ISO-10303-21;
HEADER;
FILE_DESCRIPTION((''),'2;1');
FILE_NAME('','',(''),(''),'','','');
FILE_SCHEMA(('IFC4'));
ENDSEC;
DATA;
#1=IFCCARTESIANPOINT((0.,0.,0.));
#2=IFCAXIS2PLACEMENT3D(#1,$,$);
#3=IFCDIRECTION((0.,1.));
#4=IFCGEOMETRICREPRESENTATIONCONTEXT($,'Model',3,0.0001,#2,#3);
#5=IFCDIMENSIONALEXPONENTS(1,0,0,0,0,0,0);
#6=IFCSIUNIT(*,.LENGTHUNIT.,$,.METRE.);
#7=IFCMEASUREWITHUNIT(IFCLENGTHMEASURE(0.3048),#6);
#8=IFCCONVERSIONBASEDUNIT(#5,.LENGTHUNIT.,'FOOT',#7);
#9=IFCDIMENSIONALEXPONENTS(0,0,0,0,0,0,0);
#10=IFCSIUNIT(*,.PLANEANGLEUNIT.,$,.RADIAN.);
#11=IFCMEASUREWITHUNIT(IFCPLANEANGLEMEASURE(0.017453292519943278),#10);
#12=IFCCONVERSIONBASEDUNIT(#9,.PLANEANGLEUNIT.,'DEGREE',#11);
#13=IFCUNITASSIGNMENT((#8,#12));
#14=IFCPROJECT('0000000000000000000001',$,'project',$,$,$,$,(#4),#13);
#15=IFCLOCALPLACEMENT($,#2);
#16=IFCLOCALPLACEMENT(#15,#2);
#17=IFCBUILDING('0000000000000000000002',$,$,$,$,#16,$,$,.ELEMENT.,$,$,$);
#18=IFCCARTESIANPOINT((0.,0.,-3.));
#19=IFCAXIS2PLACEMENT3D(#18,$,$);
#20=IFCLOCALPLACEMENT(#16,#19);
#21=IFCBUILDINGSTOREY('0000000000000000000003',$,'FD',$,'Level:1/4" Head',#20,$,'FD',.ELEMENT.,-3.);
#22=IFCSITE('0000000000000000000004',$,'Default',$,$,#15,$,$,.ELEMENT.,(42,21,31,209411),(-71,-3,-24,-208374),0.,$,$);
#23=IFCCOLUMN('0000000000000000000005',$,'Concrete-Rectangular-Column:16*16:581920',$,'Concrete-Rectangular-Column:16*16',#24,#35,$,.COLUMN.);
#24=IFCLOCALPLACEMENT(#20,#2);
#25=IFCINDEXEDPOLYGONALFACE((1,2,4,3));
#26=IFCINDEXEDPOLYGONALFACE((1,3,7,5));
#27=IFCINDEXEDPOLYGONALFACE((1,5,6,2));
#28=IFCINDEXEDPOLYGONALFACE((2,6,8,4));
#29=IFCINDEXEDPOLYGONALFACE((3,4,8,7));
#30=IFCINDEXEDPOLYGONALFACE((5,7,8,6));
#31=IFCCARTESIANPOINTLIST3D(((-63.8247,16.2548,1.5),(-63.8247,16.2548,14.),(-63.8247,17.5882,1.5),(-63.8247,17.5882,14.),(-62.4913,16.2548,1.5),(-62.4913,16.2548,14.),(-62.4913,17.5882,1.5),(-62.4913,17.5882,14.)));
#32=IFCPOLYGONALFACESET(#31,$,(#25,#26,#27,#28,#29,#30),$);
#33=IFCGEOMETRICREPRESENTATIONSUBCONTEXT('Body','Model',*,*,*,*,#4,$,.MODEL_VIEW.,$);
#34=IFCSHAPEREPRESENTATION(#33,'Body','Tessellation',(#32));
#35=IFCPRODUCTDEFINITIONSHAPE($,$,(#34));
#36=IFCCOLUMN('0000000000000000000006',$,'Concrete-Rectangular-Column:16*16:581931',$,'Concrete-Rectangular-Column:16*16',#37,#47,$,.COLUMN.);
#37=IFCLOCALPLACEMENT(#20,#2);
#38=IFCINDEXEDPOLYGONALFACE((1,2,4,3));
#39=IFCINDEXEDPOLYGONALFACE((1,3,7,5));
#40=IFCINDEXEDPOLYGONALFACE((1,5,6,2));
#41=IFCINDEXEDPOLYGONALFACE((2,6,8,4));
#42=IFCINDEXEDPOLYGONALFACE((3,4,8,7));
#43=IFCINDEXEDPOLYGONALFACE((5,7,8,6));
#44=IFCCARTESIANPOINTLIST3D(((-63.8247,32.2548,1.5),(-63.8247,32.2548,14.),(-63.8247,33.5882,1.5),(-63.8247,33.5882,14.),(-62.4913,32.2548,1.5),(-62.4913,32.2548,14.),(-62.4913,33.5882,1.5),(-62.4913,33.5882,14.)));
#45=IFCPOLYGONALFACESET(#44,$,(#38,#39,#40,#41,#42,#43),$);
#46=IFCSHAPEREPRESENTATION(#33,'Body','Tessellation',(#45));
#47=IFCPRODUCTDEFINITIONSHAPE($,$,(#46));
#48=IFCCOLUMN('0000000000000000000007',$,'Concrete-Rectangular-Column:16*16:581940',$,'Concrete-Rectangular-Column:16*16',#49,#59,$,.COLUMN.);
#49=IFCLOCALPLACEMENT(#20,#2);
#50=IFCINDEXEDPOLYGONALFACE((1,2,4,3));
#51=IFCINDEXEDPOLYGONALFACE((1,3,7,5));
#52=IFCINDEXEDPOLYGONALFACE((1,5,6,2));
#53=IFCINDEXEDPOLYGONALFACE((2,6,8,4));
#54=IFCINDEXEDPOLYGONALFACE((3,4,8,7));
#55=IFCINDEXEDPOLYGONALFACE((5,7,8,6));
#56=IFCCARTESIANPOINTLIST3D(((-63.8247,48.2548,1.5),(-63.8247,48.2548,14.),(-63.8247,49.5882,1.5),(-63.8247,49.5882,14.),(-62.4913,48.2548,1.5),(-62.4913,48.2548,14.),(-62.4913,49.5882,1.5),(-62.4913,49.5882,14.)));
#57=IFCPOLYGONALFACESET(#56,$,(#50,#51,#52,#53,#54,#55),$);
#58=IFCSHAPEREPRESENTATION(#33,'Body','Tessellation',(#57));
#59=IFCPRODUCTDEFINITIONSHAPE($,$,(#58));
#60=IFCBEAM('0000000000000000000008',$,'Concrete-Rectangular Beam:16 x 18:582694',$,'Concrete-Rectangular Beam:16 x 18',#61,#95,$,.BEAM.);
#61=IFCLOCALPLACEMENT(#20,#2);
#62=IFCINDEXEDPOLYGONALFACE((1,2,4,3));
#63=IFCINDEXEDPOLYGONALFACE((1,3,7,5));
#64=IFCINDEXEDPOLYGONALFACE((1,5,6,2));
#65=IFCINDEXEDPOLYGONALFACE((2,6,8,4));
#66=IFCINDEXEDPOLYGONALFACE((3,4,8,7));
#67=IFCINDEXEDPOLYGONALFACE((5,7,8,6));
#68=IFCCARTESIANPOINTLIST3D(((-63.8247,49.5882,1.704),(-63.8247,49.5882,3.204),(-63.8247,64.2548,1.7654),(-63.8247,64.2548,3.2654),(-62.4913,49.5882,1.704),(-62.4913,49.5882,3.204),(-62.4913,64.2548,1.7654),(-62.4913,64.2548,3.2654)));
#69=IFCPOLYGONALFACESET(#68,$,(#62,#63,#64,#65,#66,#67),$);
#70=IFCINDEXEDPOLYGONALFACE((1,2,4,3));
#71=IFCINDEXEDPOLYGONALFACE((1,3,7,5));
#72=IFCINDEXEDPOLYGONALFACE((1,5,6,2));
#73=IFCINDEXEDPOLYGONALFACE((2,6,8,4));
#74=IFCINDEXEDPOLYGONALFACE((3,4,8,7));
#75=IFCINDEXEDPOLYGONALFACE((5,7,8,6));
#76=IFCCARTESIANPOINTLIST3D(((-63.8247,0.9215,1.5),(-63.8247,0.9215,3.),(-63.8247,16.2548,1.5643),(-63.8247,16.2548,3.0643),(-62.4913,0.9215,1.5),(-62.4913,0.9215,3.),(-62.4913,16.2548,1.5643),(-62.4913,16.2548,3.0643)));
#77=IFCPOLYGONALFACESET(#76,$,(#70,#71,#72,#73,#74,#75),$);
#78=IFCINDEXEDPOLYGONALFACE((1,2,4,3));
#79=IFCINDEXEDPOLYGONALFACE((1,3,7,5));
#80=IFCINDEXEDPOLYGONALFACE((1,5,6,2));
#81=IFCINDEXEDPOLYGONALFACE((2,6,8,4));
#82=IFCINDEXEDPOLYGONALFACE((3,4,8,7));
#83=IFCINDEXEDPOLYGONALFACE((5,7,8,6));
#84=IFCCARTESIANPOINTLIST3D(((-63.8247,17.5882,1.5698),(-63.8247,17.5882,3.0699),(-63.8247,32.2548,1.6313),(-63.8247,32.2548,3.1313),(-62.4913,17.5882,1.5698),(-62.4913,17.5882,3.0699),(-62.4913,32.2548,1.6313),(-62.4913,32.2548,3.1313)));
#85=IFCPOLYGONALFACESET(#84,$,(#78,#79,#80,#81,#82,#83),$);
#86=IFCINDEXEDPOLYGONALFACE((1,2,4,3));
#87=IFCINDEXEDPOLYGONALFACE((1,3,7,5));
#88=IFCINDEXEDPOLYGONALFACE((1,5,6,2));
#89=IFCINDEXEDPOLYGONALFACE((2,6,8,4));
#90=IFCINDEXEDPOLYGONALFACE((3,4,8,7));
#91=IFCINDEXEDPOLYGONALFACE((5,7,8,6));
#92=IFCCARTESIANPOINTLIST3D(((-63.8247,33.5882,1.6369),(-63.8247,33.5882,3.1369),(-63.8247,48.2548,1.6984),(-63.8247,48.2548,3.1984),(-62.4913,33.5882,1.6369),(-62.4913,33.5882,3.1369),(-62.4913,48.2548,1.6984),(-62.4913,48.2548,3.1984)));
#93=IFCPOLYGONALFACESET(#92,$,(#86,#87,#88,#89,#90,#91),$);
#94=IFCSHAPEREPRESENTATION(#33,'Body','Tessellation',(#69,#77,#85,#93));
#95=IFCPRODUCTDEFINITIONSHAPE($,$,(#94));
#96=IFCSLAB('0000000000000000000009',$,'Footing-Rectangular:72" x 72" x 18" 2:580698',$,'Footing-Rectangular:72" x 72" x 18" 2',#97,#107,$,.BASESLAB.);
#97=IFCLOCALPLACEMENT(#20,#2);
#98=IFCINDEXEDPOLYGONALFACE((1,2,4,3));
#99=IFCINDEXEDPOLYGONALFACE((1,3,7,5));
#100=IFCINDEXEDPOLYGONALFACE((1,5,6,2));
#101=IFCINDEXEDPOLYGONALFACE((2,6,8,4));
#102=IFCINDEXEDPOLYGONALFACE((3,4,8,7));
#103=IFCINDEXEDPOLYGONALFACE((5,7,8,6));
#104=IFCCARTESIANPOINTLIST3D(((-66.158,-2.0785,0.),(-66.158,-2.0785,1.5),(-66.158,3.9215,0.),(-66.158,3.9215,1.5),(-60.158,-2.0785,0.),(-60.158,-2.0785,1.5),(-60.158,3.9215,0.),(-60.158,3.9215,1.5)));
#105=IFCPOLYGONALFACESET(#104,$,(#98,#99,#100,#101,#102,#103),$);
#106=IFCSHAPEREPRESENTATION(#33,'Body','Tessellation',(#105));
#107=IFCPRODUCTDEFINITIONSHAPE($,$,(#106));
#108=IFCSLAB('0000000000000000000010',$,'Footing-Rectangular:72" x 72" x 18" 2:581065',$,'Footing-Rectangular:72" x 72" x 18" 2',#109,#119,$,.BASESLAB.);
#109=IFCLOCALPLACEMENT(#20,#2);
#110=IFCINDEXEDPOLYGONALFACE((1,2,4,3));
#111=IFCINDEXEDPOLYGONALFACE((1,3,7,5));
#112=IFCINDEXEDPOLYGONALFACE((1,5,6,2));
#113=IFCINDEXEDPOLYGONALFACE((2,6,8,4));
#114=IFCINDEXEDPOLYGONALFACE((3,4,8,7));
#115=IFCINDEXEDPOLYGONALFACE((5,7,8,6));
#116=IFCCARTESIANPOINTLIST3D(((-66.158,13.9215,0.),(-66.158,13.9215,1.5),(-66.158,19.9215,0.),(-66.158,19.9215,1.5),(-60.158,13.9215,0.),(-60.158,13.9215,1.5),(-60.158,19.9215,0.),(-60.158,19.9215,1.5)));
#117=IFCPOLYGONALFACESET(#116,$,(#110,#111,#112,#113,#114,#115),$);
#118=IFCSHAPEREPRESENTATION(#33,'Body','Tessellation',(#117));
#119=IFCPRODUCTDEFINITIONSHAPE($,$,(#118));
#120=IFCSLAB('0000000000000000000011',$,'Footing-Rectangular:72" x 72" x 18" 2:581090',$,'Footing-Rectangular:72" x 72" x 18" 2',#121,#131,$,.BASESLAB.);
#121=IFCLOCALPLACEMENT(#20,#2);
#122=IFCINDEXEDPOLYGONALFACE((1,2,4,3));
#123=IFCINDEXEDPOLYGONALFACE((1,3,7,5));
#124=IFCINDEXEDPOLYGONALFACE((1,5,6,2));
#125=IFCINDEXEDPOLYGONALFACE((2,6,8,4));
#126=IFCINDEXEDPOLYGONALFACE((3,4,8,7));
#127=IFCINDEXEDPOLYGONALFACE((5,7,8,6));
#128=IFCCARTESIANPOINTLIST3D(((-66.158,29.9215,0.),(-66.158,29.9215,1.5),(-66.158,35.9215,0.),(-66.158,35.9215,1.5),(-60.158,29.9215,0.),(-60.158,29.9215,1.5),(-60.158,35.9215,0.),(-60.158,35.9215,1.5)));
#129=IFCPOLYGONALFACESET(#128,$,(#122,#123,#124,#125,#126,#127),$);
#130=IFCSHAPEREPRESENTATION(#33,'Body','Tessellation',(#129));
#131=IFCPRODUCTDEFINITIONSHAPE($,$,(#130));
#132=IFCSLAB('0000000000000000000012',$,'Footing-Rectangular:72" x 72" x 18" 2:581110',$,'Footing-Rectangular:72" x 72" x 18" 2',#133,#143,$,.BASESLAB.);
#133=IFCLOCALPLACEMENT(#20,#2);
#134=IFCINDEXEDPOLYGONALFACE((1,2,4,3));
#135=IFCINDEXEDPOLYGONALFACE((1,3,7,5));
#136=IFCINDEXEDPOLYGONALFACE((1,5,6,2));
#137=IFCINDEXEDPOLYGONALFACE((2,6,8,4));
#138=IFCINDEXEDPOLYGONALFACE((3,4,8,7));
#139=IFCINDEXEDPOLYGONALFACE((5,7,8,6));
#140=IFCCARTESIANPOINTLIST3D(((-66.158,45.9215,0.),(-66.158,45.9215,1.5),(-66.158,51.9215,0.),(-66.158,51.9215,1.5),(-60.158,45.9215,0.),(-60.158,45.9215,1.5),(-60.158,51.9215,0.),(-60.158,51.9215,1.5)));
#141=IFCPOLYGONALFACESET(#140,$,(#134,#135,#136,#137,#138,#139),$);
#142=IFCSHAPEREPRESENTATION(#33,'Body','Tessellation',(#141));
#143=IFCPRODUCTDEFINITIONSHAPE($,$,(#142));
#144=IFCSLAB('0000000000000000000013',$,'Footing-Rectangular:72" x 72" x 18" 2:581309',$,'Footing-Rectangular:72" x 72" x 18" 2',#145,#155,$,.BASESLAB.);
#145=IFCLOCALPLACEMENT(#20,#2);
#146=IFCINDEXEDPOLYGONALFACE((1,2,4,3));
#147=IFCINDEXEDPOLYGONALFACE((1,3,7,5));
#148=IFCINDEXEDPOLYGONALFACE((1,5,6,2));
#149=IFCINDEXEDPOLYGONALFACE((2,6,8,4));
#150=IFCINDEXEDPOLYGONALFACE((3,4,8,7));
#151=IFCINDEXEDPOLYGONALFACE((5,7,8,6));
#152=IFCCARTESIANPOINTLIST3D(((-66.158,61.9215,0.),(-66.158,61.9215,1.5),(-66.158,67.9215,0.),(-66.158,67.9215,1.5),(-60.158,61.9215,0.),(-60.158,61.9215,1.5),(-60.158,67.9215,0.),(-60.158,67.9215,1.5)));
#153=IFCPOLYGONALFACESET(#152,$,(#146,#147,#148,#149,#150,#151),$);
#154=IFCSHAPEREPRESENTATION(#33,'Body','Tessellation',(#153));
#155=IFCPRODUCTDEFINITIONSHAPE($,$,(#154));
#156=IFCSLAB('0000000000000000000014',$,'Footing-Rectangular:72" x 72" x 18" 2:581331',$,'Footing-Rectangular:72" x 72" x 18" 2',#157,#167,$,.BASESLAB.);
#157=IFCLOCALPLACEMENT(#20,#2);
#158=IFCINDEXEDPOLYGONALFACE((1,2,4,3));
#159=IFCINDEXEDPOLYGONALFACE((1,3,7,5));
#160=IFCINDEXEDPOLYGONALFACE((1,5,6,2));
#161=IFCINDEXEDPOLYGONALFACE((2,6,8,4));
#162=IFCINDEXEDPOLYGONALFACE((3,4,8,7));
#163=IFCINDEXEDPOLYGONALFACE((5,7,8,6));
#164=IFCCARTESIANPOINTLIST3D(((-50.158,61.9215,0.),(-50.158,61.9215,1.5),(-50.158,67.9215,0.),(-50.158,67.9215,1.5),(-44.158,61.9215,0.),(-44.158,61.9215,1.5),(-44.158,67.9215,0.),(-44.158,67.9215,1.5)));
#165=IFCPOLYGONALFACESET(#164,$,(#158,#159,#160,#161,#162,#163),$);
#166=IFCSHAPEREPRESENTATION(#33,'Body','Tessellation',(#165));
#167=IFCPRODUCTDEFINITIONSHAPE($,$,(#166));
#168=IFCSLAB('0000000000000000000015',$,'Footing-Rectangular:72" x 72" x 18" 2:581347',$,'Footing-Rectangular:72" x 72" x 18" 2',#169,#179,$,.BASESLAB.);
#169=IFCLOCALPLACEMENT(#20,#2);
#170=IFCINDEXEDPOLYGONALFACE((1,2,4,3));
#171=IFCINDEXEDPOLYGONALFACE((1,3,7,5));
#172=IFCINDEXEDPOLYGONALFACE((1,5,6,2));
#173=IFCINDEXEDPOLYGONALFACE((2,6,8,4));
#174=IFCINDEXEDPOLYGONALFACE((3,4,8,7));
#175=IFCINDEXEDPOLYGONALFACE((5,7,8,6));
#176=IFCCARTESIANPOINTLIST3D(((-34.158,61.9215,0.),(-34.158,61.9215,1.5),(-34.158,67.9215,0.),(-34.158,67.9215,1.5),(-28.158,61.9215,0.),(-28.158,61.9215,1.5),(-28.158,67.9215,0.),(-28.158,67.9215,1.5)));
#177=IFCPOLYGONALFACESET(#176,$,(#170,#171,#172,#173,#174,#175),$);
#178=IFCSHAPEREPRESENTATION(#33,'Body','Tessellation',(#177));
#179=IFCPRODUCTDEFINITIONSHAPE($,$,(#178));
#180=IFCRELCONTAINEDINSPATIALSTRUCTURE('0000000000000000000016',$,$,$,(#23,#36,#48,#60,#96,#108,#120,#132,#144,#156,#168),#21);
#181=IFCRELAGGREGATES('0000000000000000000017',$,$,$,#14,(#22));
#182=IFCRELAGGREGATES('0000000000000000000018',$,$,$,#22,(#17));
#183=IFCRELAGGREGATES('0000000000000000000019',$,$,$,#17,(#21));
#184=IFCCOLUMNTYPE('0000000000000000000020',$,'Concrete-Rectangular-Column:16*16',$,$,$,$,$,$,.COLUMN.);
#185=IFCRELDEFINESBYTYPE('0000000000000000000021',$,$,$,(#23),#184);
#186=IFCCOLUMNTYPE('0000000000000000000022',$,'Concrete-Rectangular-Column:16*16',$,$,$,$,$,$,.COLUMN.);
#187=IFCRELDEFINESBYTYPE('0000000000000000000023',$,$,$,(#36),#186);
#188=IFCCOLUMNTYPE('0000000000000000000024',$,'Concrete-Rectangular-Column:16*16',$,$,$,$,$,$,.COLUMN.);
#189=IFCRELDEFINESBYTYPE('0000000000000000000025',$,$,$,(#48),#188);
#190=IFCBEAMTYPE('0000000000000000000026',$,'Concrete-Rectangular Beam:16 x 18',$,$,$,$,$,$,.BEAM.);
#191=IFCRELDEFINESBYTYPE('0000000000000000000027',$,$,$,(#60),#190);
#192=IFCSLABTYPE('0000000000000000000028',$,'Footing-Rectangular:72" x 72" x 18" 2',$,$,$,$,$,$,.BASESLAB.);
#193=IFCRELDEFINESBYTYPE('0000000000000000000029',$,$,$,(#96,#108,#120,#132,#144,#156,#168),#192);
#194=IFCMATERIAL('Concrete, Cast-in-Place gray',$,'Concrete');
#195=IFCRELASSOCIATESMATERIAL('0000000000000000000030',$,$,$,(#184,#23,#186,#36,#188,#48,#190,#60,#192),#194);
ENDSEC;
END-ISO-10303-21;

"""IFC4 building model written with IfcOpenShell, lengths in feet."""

from ifc_helpers import new_model, entity, si_unit, converted_unit, direction, frame, origin, place, context, subcontext, project, spatial, indexed_curve, outline, extrude, source, transform, mapped, material, type_object, type_shapes, element, save


model = new_model("IFC4")

# Units and contexts
model_context = context("Model", 3, precision=0.0001, world=origin(), true_north=direction((0.0, 1.0)))
body_context = subcontext(model_context, "Body", "Model", "MODEL_VIEW")
ifc_project = project(units=[converted_unit("LENGTHUNIT", "FOOT", entity("IfcLengthMeasure", 0.3048), si_unit("LENGTHUNIT", "METRE"), dimensions=[1, 0, 0, 0, 0, 0, 0]), converted_unit("PLANEANGLEUNIT", "DEGREE", entity("IfcPlaneAngleMeasure", 0.017453292519943278), si_unit("PLANEANGLEUNIT", "RADIAN"), dimensions=[0, 0, 0, 0, 0, 0, 0])], contexts=[model_context])

# Site, building, storey
site_placement = place(None, origin())
site = spatial("IfcSite", under=ifc_project, at=site_placement, Name="Default", CompositionType="ELEMENT", RefLatitude=(42, 21, 31, 209411), RefLongitude=(-71, -3, -24, -208374), RefElevation=0.0)
building_placement = place(site_placement, origin())
building = spatial("IfcBuilding", under=site, at=building_placement, CompositionType="ELEMENT")
storey_placement = place(building_placement, frame((0.0, 0.0, -3.0)))
storey = spatial("IfcBuildingStorey", under=building, at=storey_placement, Name="FD", ObjectType="Level:1/4\" Head", LongName="FD", CompositionType="ELEMENT", Elevation=-3.0)

# Columns
ifc_material = material(Name="Concrete, Cast-in-Place gray", Category="Concrete")
column_type_1 = type_object("IfcColumnType", Name="Concrete-Rectangular-Column:16*16", PredefinedType="COLUMN", material=ifc_material)
shared_shape_1 = source(origin(), body_context, "Body", "SweptSolid", [
    extrude(outline(indexed_curve([(-0.6667, -0.6667), (0.6667, -0.6667), (0.6667, 0.6667), (-0.6667, 0.6667), (-0.6667, -0.6667)], self_intersect=False)), frame((-63.158, 16.9215, -1.5), z_axis=(0.0, 0.0, 1.0), x_axis=(-1.0, 0.0, 0.0)), (0.0, 0.0, 1.0), 12.5),
])
type_shapes(column_type_1, [shared_shape_1])
column_1_placement = place(storey_placement, frame((0.0, 0.0, 3.0)))
element("IfcColumn", 1, at=column_1_placement, inside=storey, type_object=column_type_1, material=ifc_material, Name="Concrete-Rectangular-Column:16*16:581920", ObjectType="Concrete-Rectangular-Column:16*16", PredefinedType="COLUMN", context=body_context, shape_type="MappedRepresentation", body=[
    mapped(shared_shape_1, transform((0.0, 0.0, 0.0), scale=1.0)),
])
column_type_2 = type_object("IfcColumnType", Name="Concrete-Rectangular-Column:16*16", PredefinedType="COLUMN", material=ifc_material)
shared_shape_2 = source(origin(), body_context, "Body", "SweptSolid", [
    extrude(outline(indexed_curve([(-0.6667, -0.6667), (0.6667, -0.6667), (0.6667, 0.6667), (-0.6667, 0.6667), (-0.6667, -0.6667)], self_intersect=False)), frame((-63.158, 32.9215, -1.5), z_axis=(0.0, 0.0, 1.0), x_axis=(-1.0, 0.0, 0.0)), (0.0, 0.0, 1.0), 12.5),
])
type_shapes(column_type_2, [shared_shape_2])
column_2_placement = place(storey_placement, frame((0.0, 0.0, 3.0)))
element("IfcColumn", 2, at=column_2_placement, inside=storey, type_object=column_type_2, material=ifc_material, Name="Concrete-Rectangular-Column:16*16:581931", ObjectType="Concrete-Rectangular-Column:16*16", PredefinedType="COLUMN", context=body_context, shape_type="MappedRepresentation", body=[
    mapped(shared_shape_2, transform((0.0, 0.0, 0.0), scale=1.0)),
])
column_type_3 = type_object("IfcColumnType", Name="Concrete-Rectangular-Column:16*16", PredefinedType="COLUMN", material=ifc_material)
shared_shape_3 = source(origin(), body_context, "Body", "SweptSolid", [
    extrude(outline(indexed_curve([(-0.6667, -0.6667), (0.6667, -0.6667), (0.6667, 0.6667), (-0.6667, 0.6667), (-0.6667, -0.6667)], self_intersect=False)), frame((-63.158, 48.9215, -1.5), z_axis=(0.0, 0.0, 1.0), x_axis=(-1.0, 0.0, 0.0)), (0.0, 0.0, 1.0), 12.5),
])
type_shapes(column_type_3, [shared_shape_3])
column_3_placement = place(storey_placement, frame((0.0, 0.0, 3.0)))
element("IfcColumn", 3, at=column_3_placement, inside=storey, type_object=column_type_3, material=ifc_material, Name="Concrete-Rectangular-Column:16*16:581940", ObjectType="Concrete-Rectangular-Column:16*16", PredefinedType="COLUMN", context=body_context, shape_type="MappedRepresentation", body=[
    mapped(shared_shape_3, transform((0.0, 0.0, 0.0), scale=1.0)),
])

# Beam
beam_type = type_object("IfcBeamType", Name="Concrete-Rectangular Beam:16 x 18", PredefinedType="BEAM", material=ifc_material)
shared_shape_4 = source(origin(), body_context, "Body", "SweptSolid", [
    extrude(outline(indexed_curve([(-7.3365, -0.75), (7.3303, -0.75), (7.3365, 0.75), (-7.3303, 0.75), (-7.3365, -0.75)], self_intersect=False)), frame((-63.8247, 56.9215, -0.5153), z_axis=(1.0, 0.0, 0.0), x_axis=(0.0, -0.999991, -0.004191)), (0.0, 0.0, 1.0), 1.3333),
    extrude(outline(indexed_curve([(-7.6699, -0.75), (7.6636, -0.75), (7.6699, 0.75), (-7.6636, 0.75), (-7.6699, -0.75)], self_intersect=False)), frame((-63.8247, 8.5882, -0.7179), z_axis=(1.0, 0.0, 0.0), x_axis=(0.0, 0.999991, 0.004191)), (0.0, 0.0, 1.0), 1.3333),
    extrude(outline(indexed_curve([(-7.3365, -0.75), (7.3303, -0.75), (7.3365, 0.75), (-7.3303, 0.75), (-7.3365, -0.75)], self_intersect=False)), frame((-63.8247, 24.9215, -0.6494), z_axis=(1.0, 0.0, 0.0), x_axis=(0.0, 0.999991, 0.004191)), (0.0, 0.0, 1.0), 1.3333),
    extrude(outline(indexed_curve([(-7.3365, -0.75), (7.3303, -0.75), (7.3365, 0.75), (-7.3303, 0.75), (-7.3365, -0.75)], self_intersect=False)), frame((-63.8247, 40.9215, -0.5824), z_axis=(1.0, 0.0, 0.0), x_axis=(0.0, 0.999991, 0.004191)), (0.0, 0.0, 1.0), 1.3333),
])
type_shapes(beam_type, [shared_shape_4])
beam_placement = place(storey_placement, frame((0.0, 0.0, 3.0)))
element("IfcBeam", 4, at=beam_placement, inside=storey, type_object=beam_type, material=ifc_material, Name="Concrete-Rectangular Beam:16 x 18:582694", ObjectType="Concrete-Rectangular Beam:16 x 18", PredefinedType="BEAM", context=body_context, shape_type="MappedRepresentation", body=[
    mapped(shared_shape_4, transform((0.0, 0.0, 0.0), scale=1.0)),
])

# Slabs
slab_type_1 = type_object("IfcSlabType", Name="Footing-Rectangular:72\" x 72\" x 18\" 2", PredefinedType="BASESLAB", material=ifc_material)
slab_1_placement = place(storey_placement, origin())
element("IfcSlab", 5, at=slab_1_placement, inside=storey, type_object=slab_type_1, Name="Footing-Rectangular:72\" x 72\" x 18\" 2:580698", ObjectType="Footing-Rectangular:72\" x 72\" x 18\" 2", PredefinedType="BASESLAB", context=body_context, shape_type="SweptSolid", body=[
    extrude(outline(indexed_curve([(-3.0, -3.0), (3.0, -3.0), (3.0, 3.0), (-3.0, 3.0), (-3.0, -3.0)], self_intersect=False)), frame((-63.158, 0.9215, 0.0), z_axis=(0.0, 0.0, 1.0), x_axis=(-1.0, 0.0, 0.0)), (0.0, 0.0, 1.0), 1.5),
])
slab_2_placement = place(storey_placement, origin())
element("IfcSlab", 6, at=slab_2_placement, inside=storey, type_object=slab_type_1, Name="Footing-Rectangular:72\" x 72\" x 18\" 2:581065", ObjectType="Footing-Rectangular:72\" x 72\" x 18\" 2", PredefinedType="BASESLAB", context=body_context, shape_type="SweptSolid", body=[
    extrude(outline(indexed_curve([(-3.0, -3.0), (3.0, -3.0), (3.0, 3.0), (-3.0, 3.0), (-3.0, -3.0)], self_intersect=False)), frame((-63.158, 16.9215, 0.0), z_axis=(0.0, 0.0, 1.0), x_axis=(-1.0, 0.0, 0.0)), (0.0, 0.0, 1.0), 1.5),
])
slab_3_placement = place(storey_placement, origin())
element("IfcSlab", 7, at=slab_3_placement, inside=storey, type_object=slab_type_1, Name="Footing-Rectangular:72\" x 72\" x 18\" 2:581090", ObjectType="Footing-Rectangular:72\" x 72\" x 18\" 2", PredefinedType="BASESLAB", context=body_context, shape_type="SweptSolid", body=[
    extrude(outline(indexed_curve([(-3.0, -3.0), (3.0, -3.0), (3.0, 3.0), (-3.0, 3.0), (-3.0, -3.0)], self_intersect=False)), frame((-63.158, 32.9215, 0.0), z_axis=(0.0, 0.0, 1.0), x_axis=(-1.0, 0.0, 0.0)), (0.0, 0.0, 1.0), 1.5),
])
slab_4_placement = place(storey_placement, origin())
element("IfcSlab", 8, at=slab_4_placement, inside=storey, type_object=slab_type_1, Name="Footing-Rectangular:72\" x 72\" x 18\" 2:581110", ObjectType="Footing-Rectangular:72\" x 72\" x 18\" 2", PredefinedType="BASESLAB", context=body_context, shape_type="SweptSolid", body=[
    extrude(outline(indexed_curve([(-3.0, -3.0), (3.0, -3.0), (3.0, 3.0), (-3.0, 3.0), (-3.0, -3.0)], self_intersect=False)), frame((-63.158, 48.9215, 0.0), z_axis=(0.0, 0.0, 1.0), x_axis=(-1.0, 0.0, 0.0)), (0.0, 0.0, 1.0), 1.5),
])
slab_5_placement = place(storey_placement, origin())
element("IfcSlab", 9, at=slab_5_placement, inside=storey, type_object=slab_type_1, Name="Footing-Rectangular:72\" x 72\" x 18\" 2:581309", ObjectType="Footing-Rectangular:72\" x 72\" x 18\" 2", PredefinedType="BASESLAB", context=body_context, shape_type="SweptSolid", body=[
    extrude(outline(indexed_curve([(-3.0, -3.0), (3.0, -3.0), (3.0, 3.0), (-3.0, 3.0), (-3.0, -3.0)], self_intersect=False)), frame((-63.158, 64.9215, 0.0), z_axis=(0.0, 0.0, 1.0), x_axis=(-1.0, 0.0, 0.0)), (0.0, 0.0, 1.0), 1.5),
])
slab_6_placement = place(storey_placement, origin())
element("IfcSlab", 10, at=slab_6_placement, inside=storey, type_object=slab_type_1, Name="Footing-Rectangular:72\" x 72\" x 18\" 2:581331", ObjectType="Footing-Rectangular:72\" x 72\" x 18\" 2", PredefinedType="BASESLAB", context=body_context, shape_type="SweptSolid", body=[
    extrude(outline(indexed_curve([(-3.0, -3.0), (3.0, -3.0), (3.0, 3.0), (-3.0, 3.0), (-3.0, -3.0)], self_intersect=False)), frame((-47.158, 64.9215, 0.0), z_axis=(0.0, 0.0, 1.0), x_axis=(-1.0, 0.0, 0.0)), (0.0, 0.0, 1.0), 1.5),
])
slab_7_placement = place(storey_placement, origin())
element("IfcSlab", 11, at=slab_7_placement, inside=storey, type_object=slab_type_1, Name="Footing-Rectangular:72\" x 72\" x 18\" 2:581347", ObjectType="Footing-Rectangular:72\" x 72\" x 18\" 2", PredefinedType="BASESLAB", context=body_context, shape_type="SweptSolid", body=[
    extrude(outline(indexed_curve([(-3.0, -3.0), (3.0, -3.0), (3.0, 3.0), (-3.0, 3.0), (-3.0, -3.0)], self_intersect=False)), frame((-31.158, 64.9215, 0.0), z_axis=(0.0, 0.0, 1.0), x_axis=(-1.0, 0.0, 0.0)), (0.0, 0.0, 1.0), 1.5),
])

save(model, "model.ifc")
